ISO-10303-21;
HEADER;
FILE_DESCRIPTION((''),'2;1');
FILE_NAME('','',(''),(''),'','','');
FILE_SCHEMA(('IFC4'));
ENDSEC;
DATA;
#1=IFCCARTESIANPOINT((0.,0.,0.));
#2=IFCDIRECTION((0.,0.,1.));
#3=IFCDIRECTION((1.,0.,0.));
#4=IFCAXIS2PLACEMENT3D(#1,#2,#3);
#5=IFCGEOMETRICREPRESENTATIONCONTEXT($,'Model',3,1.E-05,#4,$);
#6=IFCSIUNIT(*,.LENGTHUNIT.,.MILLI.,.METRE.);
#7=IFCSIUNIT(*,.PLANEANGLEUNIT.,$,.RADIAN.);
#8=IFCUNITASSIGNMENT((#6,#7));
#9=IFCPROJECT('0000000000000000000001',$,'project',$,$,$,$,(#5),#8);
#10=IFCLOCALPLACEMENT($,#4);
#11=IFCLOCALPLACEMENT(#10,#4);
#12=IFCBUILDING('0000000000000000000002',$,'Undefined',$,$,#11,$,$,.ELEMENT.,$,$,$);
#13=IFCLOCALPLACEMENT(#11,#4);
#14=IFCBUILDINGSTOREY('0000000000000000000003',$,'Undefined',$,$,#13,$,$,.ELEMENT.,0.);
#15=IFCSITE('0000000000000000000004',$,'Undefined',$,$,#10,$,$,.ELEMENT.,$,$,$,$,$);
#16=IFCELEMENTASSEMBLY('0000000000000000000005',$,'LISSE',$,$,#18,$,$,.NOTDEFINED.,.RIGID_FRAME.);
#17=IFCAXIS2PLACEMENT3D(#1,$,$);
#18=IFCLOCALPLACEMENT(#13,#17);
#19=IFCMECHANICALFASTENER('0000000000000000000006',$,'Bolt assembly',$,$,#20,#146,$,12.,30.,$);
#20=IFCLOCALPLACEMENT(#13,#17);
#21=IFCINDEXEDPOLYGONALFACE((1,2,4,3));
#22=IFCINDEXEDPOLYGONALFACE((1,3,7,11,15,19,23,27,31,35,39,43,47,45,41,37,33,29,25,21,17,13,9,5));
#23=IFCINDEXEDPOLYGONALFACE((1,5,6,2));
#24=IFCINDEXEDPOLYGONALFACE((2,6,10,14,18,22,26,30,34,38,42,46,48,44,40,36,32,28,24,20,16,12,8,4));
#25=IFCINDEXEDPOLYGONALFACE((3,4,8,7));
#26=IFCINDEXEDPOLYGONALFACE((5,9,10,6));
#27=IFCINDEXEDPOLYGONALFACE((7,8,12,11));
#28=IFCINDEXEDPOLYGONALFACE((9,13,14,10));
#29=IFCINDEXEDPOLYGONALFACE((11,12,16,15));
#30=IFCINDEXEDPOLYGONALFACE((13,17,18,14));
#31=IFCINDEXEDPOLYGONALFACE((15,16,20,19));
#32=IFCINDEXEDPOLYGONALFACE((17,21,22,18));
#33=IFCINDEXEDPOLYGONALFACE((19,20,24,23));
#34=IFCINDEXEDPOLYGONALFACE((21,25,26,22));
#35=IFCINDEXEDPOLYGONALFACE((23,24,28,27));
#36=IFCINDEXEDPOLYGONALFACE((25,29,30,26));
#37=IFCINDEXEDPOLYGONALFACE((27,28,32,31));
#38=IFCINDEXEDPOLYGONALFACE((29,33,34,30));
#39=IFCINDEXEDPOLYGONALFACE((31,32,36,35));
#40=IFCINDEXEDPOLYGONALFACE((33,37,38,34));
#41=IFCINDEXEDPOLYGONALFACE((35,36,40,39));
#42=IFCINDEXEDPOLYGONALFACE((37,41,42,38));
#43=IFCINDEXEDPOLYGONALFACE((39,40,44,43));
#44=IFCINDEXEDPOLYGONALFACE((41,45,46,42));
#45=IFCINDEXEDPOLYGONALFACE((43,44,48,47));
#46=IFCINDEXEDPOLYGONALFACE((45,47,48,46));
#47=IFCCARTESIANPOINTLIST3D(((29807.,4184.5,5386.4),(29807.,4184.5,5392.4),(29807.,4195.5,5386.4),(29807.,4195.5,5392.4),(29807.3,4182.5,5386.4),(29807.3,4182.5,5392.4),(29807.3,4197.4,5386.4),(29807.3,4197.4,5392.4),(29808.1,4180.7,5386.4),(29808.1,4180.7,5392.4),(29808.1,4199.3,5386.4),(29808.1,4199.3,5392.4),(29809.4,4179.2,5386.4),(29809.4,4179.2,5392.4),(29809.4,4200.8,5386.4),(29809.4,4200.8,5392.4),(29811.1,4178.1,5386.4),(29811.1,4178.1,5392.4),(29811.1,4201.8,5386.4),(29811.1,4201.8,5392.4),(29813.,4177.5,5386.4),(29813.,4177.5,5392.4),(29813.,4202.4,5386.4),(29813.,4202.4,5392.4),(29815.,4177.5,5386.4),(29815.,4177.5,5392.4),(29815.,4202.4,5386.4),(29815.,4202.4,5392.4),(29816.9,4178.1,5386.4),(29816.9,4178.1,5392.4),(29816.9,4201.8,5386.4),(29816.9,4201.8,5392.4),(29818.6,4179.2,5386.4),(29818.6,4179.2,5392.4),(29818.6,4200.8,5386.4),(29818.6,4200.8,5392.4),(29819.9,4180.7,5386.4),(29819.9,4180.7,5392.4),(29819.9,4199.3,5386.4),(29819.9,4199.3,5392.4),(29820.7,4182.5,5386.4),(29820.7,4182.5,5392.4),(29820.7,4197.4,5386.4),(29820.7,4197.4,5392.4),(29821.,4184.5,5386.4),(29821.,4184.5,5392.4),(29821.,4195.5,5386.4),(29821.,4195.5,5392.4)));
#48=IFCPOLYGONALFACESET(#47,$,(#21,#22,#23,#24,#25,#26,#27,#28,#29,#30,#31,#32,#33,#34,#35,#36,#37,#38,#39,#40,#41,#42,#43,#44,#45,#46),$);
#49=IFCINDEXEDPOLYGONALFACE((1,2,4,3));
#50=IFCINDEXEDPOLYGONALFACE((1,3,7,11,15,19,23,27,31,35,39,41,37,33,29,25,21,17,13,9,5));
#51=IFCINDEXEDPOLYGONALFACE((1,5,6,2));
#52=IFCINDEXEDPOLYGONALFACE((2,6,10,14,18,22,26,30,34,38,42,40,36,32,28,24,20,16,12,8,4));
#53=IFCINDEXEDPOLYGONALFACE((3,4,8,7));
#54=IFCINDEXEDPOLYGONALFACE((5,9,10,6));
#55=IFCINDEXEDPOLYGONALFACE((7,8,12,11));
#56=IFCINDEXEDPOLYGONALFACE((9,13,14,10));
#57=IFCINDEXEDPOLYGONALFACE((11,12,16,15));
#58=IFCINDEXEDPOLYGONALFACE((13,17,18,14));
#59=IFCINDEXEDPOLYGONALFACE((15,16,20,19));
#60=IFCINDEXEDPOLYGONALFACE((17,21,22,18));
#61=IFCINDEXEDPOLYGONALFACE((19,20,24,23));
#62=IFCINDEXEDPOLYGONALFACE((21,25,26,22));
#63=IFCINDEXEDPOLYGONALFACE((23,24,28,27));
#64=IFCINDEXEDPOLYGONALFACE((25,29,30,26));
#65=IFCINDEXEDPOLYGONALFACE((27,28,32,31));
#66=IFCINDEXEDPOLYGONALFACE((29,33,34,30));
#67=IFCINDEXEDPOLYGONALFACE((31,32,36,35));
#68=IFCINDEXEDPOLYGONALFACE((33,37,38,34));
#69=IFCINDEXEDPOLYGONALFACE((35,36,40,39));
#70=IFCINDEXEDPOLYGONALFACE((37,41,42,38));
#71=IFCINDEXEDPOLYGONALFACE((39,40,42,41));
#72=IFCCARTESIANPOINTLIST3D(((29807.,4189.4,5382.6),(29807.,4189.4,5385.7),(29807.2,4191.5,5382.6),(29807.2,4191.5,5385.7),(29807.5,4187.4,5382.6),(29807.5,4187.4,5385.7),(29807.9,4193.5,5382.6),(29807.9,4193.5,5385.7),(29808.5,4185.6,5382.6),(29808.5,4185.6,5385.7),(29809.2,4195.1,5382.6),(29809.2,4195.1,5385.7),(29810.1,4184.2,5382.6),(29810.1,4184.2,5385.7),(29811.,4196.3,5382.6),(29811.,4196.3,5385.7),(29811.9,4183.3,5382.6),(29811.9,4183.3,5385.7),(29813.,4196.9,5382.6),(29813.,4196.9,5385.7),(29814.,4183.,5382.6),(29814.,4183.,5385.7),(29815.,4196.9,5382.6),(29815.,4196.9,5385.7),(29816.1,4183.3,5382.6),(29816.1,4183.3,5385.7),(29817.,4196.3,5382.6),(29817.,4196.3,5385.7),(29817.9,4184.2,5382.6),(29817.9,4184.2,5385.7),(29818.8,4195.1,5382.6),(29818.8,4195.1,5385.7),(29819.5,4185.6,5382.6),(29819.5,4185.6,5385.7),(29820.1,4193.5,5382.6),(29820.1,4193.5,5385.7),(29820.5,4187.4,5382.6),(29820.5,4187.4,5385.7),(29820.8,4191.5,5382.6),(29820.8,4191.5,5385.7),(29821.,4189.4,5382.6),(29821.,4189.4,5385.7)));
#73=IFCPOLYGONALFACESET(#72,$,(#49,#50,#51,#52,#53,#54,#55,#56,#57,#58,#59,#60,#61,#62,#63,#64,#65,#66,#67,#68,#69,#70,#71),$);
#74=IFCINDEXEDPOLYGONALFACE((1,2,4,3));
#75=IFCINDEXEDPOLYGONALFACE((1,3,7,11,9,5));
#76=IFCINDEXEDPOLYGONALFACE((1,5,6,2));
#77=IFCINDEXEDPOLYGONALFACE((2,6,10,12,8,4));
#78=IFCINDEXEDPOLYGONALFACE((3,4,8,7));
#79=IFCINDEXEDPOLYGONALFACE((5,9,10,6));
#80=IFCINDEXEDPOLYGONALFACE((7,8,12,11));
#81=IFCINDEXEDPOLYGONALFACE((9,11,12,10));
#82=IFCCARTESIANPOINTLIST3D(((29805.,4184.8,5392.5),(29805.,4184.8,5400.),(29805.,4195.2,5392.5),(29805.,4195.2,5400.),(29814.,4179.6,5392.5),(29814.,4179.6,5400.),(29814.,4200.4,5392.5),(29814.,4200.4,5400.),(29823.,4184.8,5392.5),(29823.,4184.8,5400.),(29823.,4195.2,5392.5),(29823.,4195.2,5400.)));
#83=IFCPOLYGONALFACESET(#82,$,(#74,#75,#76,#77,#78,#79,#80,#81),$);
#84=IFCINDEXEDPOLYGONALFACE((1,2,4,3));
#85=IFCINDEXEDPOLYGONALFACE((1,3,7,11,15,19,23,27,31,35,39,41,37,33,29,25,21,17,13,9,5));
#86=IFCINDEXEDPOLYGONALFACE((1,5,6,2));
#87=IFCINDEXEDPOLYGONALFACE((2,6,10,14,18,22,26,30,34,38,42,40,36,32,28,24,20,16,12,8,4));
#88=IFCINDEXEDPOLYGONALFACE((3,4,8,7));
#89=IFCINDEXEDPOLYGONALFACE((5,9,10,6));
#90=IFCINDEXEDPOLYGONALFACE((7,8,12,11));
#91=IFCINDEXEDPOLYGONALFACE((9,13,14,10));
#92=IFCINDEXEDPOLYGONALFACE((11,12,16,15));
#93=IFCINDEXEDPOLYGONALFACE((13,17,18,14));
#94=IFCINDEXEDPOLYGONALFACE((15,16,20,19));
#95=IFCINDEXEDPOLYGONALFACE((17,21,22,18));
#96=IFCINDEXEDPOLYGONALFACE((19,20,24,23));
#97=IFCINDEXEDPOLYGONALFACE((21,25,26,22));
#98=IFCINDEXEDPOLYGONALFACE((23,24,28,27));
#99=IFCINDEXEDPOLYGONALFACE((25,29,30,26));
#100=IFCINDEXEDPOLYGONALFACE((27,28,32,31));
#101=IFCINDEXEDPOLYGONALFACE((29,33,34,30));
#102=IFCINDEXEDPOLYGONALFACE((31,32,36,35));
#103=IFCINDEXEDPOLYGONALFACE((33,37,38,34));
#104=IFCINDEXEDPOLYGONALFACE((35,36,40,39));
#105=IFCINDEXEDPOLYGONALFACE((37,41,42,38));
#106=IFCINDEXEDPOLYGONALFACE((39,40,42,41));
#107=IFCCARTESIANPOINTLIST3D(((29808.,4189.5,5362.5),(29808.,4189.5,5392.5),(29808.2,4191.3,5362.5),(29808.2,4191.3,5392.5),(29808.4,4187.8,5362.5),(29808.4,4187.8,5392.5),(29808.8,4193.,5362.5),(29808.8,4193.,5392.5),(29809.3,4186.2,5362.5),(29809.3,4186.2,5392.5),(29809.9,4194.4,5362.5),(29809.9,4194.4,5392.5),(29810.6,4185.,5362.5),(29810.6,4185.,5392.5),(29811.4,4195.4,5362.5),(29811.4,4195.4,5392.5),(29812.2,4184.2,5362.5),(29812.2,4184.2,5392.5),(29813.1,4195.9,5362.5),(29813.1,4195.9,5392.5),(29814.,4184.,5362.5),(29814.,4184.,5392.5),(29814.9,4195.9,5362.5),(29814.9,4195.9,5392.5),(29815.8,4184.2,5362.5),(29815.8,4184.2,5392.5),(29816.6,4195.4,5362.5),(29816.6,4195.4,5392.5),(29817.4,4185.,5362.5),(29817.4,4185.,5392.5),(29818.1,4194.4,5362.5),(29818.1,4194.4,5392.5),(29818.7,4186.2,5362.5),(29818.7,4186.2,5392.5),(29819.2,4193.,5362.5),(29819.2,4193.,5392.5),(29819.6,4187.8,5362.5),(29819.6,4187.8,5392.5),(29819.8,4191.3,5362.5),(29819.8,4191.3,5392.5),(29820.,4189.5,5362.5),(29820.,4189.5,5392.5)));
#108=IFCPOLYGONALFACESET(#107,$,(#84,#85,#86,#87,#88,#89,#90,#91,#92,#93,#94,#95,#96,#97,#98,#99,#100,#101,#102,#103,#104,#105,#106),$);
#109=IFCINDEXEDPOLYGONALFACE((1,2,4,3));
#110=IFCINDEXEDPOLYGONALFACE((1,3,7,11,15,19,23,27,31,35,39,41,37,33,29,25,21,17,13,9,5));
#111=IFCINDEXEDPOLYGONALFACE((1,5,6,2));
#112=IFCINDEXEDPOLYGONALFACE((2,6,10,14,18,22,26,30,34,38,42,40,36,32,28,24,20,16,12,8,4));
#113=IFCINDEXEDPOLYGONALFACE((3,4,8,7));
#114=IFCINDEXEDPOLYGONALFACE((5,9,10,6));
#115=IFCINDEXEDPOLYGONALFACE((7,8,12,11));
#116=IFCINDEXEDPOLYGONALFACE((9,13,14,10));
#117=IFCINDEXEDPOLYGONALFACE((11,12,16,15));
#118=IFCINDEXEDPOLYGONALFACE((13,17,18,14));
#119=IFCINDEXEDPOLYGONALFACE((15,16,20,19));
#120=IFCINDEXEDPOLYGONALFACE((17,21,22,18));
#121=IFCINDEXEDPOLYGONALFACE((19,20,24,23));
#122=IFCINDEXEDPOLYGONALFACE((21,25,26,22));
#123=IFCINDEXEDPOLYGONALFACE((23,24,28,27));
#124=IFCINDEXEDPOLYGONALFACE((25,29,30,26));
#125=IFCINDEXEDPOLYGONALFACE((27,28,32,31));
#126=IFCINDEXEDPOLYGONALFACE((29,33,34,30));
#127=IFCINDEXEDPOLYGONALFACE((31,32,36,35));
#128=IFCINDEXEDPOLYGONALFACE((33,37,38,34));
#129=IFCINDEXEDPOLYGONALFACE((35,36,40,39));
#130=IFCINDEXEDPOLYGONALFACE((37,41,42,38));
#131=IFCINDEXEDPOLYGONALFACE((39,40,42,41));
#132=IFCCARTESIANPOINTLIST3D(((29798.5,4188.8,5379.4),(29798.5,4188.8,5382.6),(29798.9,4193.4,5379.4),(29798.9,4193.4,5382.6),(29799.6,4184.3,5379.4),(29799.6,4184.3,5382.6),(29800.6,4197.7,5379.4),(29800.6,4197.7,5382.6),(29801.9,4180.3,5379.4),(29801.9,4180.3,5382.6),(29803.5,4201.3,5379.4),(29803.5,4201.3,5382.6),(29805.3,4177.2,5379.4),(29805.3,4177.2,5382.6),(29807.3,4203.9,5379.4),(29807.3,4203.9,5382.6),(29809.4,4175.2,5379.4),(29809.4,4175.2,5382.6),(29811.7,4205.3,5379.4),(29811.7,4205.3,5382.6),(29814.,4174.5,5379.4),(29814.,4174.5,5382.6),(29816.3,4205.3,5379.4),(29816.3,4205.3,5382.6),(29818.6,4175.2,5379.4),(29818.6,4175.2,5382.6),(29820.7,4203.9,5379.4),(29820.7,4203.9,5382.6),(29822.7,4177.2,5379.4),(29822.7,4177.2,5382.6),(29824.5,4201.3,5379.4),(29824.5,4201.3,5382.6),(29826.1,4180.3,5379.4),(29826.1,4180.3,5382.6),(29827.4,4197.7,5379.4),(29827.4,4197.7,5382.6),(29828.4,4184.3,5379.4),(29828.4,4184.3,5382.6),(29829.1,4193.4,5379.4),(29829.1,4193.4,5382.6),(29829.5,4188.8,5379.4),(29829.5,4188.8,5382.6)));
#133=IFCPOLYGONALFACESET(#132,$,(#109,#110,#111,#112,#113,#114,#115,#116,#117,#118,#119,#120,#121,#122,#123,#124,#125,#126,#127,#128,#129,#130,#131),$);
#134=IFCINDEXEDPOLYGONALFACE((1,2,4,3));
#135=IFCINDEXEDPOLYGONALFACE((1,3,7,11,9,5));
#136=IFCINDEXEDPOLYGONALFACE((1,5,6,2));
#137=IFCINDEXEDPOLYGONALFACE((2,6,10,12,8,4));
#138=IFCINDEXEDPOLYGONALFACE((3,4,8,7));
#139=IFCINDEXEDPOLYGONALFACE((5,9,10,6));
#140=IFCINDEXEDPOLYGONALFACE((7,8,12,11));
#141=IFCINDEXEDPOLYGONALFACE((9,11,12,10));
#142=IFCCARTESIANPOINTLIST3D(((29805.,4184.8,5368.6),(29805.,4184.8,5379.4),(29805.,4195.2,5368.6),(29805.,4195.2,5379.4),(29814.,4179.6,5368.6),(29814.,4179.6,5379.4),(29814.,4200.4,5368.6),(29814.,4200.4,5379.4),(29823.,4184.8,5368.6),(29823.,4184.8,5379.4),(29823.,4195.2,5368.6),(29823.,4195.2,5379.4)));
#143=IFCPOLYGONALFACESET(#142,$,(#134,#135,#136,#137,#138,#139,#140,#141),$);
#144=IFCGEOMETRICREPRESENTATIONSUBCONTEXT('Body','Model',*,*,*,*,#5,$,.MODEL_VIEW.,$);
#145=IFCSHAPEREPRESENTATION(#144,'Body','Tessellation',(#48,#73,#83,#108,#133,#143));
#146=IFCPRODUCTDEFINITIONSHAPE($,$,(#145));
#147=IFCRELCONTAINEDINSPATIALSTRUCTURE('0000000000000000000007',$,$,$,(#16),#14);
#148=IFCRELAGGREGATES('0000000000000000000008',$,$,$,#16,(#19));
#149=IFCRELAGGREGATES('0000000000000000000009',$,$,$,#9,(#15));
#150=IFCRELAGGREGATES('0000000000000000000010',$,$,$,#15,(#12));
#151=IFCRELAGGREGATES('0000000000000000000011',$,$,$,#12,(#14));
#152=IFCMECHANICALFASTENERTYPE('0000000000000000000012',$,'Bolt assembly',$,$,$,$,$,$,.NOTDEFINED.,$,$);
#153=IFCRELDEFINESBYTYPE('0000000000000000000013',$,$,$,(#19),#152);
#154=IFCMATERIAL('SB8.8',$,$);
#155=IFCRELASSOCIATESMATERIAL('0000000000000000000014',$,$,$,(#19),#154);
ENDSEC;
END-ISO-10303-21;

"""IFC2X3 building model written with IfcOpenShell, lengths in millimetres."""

from ifc_helpers import new_model, si_unit, frame, frame_2d, origin_with_axes, origin_2d_with_axis, place, context, subcontext, project, spatial, polyline, circle_curve, parameter, trimmed, segment, composite_curve, circle, outline, extrude, source, transform, mapped, material, type_object, element, aggregate, save


model = new_model("IFC2X3")

# Units and contexts
model_context = context("Model", 3, precision=1e-05, world=origin_with_axes())
body_context = subcontext(model_context, "Body", "Model", "MODEL_VIEW")
ifc_project = project(units=[si_unit("LENGTHUNIT", "METRE", prefix="MILLI"), si_unit("PLANEANGLEUNIT", "RADIAN")], contexts=[model_context])

# Site, building, storey
site_placement = place(None, origin_with_axes())
site = spatial("IfcSite", under=ifc_project, at=site_placement, Name="Undefined", CompositionType="ELEMENT")
building_placement = place(site_placement, origin_with_axes())
building = spatial("IfcBuilding", under=site, at=building_placement, Name="Undefined", CompositionType="ELEMENT")
storey_placement = place(building_placement, origin_with_axes())
storey = spatial("IfcBuildingStorey", under=building, at=storey_placement, Name="Undefined", CompositionType="ELEMENT", Elevation=0.0)

# Shared definitions
ifc_material_1 = material(Name="SB8.8")
mechanical_fastener_type = type_object("IfcMechanicalFastenerType", Name="Bolt assembly")

# Element assembly, mechanical fastener
assembly_1_placement = place(storey_placement, origin_with_axes())
assembly_1 = element("IfcElementAssembly", 1, at=assembly_1_placement, inside=storey, Name="LISSE", AssemblyPlace="NOTDEFINED", PredefinedType="RIGID_FRAME")
shared_shape_1 = source(origin_with_axes(), body_context, "Body", "SweptSolid", [
    extrude(outline(composite_curve([segment(polyline([(-5.5, 7.0), (5.5, 7.0)]), True, "CONTINUOUS"), segment(trimmed(circle_curve(frame_2d((5.5, 0.0), x_axis=(0.0, 1.0)), 7.0), [parameter(0.0)], [parameter(3.141593)], False, "PARAMETER"), True, "CONTINUOUS"), segment(polyline([(5.5, -7.0), (-5.5, -7.0)]), True, "CONTINUOUS"), segment(trimmed(circle_curve(frame_2d((-5.5, 0.0), x_axis=(0.0, -1.0)), 7.0), [parameter(0.0)], [parameter(3.141593)], False, "PARAMETER"), True, "DISCONTINUOUS")], self_intersect=False)), frame((0.0, -5.9, 0.0), z_axis=(0.0, 1.0, 0.0), x_axis=(1.0, 0.0, 0.0)), (0.0, 0.0, 1.0), 6.0),
    extrude(circle(Radius=7.0, at=origin_2d_with_axis()), frame((0.0, 0.8, 0.0), z_axis=(0.0, 1.0, 0.0), x_axis=(1.0, 0.0, 0.0)), (0.0, 0.0, 1.0), 3.1),
    extrude(outline(polyline([(10.4, 0.0), (5.2, 9.0), (-5.2, 9.0), (-10.4, 0.0), (-5.2, -9.0), (5.2, -9.0), (10.4, 0.0)])), frame((0.0, -13.5, 0.0), z_axis=(0.0, 1.0, 0.0), x_axis=(1.0, 0.0, 0.0)), (0.0, 0.0, 1.0), 7.5),
    extrude(circle(Radius=6.0, at=origin_2d_with_axis()), frame((0.0, -6.0, 0.0), z_axis=(0.0, 1.0, 0.0), x_axis=(1.0, 0.0, 0.0)), (0.0, 0.0, 1.0), 30.0),
    extrude(circle(Radius=15.5, at=origin_2d_with_axis()), frame((0.0, 3.9, 0.0), z_axis=(0.0, 1.0, 0.0), x_axis=(1.0, 0.0, 0.0)), (0.0, 0.0, 1.0), 3.2),
    extrude(outline(polyline([(10.4, 0.0), (5.2, 9.0), (-5.2, 9.0), (-10.4, 0.0), (-5.2, -9.0), (5.2, -9.0), (10.4, 0.0)])), frame((0.0, 7.1, 0.0), z_axis=(0.0, 1.0, 0.0), x_axis=(1.0, 0.0, 0.0)), (0.0, 0.0, 1.0), 10.8),
])
mechanical_fastener_1_placement = place(assembly_1_placement, frame((29814.0, 4190.0, 5386.5), z_axis=(1.0, 0.0, 0.0), x_axis=(0.0, -1.0, 0.0)))
mechanical_fastener_1 = element("IfcMechanicalFastener", 2, at=mechanical_fastener_1_placement, type_object=mechanical_fastener_type, material=ifc_material_1, Name="Bolt assembly", NominalDiameter=12.0, NominalLength=30.0, context=body_context, shape_type="MappedRepresentation", body=[
    mapped(shared_shape_1, transform((0.0, 0.0, 0.0))),
])
aggregate(assembly_1, [mechanical_fastener_1])

save(model, "model.ifc")
